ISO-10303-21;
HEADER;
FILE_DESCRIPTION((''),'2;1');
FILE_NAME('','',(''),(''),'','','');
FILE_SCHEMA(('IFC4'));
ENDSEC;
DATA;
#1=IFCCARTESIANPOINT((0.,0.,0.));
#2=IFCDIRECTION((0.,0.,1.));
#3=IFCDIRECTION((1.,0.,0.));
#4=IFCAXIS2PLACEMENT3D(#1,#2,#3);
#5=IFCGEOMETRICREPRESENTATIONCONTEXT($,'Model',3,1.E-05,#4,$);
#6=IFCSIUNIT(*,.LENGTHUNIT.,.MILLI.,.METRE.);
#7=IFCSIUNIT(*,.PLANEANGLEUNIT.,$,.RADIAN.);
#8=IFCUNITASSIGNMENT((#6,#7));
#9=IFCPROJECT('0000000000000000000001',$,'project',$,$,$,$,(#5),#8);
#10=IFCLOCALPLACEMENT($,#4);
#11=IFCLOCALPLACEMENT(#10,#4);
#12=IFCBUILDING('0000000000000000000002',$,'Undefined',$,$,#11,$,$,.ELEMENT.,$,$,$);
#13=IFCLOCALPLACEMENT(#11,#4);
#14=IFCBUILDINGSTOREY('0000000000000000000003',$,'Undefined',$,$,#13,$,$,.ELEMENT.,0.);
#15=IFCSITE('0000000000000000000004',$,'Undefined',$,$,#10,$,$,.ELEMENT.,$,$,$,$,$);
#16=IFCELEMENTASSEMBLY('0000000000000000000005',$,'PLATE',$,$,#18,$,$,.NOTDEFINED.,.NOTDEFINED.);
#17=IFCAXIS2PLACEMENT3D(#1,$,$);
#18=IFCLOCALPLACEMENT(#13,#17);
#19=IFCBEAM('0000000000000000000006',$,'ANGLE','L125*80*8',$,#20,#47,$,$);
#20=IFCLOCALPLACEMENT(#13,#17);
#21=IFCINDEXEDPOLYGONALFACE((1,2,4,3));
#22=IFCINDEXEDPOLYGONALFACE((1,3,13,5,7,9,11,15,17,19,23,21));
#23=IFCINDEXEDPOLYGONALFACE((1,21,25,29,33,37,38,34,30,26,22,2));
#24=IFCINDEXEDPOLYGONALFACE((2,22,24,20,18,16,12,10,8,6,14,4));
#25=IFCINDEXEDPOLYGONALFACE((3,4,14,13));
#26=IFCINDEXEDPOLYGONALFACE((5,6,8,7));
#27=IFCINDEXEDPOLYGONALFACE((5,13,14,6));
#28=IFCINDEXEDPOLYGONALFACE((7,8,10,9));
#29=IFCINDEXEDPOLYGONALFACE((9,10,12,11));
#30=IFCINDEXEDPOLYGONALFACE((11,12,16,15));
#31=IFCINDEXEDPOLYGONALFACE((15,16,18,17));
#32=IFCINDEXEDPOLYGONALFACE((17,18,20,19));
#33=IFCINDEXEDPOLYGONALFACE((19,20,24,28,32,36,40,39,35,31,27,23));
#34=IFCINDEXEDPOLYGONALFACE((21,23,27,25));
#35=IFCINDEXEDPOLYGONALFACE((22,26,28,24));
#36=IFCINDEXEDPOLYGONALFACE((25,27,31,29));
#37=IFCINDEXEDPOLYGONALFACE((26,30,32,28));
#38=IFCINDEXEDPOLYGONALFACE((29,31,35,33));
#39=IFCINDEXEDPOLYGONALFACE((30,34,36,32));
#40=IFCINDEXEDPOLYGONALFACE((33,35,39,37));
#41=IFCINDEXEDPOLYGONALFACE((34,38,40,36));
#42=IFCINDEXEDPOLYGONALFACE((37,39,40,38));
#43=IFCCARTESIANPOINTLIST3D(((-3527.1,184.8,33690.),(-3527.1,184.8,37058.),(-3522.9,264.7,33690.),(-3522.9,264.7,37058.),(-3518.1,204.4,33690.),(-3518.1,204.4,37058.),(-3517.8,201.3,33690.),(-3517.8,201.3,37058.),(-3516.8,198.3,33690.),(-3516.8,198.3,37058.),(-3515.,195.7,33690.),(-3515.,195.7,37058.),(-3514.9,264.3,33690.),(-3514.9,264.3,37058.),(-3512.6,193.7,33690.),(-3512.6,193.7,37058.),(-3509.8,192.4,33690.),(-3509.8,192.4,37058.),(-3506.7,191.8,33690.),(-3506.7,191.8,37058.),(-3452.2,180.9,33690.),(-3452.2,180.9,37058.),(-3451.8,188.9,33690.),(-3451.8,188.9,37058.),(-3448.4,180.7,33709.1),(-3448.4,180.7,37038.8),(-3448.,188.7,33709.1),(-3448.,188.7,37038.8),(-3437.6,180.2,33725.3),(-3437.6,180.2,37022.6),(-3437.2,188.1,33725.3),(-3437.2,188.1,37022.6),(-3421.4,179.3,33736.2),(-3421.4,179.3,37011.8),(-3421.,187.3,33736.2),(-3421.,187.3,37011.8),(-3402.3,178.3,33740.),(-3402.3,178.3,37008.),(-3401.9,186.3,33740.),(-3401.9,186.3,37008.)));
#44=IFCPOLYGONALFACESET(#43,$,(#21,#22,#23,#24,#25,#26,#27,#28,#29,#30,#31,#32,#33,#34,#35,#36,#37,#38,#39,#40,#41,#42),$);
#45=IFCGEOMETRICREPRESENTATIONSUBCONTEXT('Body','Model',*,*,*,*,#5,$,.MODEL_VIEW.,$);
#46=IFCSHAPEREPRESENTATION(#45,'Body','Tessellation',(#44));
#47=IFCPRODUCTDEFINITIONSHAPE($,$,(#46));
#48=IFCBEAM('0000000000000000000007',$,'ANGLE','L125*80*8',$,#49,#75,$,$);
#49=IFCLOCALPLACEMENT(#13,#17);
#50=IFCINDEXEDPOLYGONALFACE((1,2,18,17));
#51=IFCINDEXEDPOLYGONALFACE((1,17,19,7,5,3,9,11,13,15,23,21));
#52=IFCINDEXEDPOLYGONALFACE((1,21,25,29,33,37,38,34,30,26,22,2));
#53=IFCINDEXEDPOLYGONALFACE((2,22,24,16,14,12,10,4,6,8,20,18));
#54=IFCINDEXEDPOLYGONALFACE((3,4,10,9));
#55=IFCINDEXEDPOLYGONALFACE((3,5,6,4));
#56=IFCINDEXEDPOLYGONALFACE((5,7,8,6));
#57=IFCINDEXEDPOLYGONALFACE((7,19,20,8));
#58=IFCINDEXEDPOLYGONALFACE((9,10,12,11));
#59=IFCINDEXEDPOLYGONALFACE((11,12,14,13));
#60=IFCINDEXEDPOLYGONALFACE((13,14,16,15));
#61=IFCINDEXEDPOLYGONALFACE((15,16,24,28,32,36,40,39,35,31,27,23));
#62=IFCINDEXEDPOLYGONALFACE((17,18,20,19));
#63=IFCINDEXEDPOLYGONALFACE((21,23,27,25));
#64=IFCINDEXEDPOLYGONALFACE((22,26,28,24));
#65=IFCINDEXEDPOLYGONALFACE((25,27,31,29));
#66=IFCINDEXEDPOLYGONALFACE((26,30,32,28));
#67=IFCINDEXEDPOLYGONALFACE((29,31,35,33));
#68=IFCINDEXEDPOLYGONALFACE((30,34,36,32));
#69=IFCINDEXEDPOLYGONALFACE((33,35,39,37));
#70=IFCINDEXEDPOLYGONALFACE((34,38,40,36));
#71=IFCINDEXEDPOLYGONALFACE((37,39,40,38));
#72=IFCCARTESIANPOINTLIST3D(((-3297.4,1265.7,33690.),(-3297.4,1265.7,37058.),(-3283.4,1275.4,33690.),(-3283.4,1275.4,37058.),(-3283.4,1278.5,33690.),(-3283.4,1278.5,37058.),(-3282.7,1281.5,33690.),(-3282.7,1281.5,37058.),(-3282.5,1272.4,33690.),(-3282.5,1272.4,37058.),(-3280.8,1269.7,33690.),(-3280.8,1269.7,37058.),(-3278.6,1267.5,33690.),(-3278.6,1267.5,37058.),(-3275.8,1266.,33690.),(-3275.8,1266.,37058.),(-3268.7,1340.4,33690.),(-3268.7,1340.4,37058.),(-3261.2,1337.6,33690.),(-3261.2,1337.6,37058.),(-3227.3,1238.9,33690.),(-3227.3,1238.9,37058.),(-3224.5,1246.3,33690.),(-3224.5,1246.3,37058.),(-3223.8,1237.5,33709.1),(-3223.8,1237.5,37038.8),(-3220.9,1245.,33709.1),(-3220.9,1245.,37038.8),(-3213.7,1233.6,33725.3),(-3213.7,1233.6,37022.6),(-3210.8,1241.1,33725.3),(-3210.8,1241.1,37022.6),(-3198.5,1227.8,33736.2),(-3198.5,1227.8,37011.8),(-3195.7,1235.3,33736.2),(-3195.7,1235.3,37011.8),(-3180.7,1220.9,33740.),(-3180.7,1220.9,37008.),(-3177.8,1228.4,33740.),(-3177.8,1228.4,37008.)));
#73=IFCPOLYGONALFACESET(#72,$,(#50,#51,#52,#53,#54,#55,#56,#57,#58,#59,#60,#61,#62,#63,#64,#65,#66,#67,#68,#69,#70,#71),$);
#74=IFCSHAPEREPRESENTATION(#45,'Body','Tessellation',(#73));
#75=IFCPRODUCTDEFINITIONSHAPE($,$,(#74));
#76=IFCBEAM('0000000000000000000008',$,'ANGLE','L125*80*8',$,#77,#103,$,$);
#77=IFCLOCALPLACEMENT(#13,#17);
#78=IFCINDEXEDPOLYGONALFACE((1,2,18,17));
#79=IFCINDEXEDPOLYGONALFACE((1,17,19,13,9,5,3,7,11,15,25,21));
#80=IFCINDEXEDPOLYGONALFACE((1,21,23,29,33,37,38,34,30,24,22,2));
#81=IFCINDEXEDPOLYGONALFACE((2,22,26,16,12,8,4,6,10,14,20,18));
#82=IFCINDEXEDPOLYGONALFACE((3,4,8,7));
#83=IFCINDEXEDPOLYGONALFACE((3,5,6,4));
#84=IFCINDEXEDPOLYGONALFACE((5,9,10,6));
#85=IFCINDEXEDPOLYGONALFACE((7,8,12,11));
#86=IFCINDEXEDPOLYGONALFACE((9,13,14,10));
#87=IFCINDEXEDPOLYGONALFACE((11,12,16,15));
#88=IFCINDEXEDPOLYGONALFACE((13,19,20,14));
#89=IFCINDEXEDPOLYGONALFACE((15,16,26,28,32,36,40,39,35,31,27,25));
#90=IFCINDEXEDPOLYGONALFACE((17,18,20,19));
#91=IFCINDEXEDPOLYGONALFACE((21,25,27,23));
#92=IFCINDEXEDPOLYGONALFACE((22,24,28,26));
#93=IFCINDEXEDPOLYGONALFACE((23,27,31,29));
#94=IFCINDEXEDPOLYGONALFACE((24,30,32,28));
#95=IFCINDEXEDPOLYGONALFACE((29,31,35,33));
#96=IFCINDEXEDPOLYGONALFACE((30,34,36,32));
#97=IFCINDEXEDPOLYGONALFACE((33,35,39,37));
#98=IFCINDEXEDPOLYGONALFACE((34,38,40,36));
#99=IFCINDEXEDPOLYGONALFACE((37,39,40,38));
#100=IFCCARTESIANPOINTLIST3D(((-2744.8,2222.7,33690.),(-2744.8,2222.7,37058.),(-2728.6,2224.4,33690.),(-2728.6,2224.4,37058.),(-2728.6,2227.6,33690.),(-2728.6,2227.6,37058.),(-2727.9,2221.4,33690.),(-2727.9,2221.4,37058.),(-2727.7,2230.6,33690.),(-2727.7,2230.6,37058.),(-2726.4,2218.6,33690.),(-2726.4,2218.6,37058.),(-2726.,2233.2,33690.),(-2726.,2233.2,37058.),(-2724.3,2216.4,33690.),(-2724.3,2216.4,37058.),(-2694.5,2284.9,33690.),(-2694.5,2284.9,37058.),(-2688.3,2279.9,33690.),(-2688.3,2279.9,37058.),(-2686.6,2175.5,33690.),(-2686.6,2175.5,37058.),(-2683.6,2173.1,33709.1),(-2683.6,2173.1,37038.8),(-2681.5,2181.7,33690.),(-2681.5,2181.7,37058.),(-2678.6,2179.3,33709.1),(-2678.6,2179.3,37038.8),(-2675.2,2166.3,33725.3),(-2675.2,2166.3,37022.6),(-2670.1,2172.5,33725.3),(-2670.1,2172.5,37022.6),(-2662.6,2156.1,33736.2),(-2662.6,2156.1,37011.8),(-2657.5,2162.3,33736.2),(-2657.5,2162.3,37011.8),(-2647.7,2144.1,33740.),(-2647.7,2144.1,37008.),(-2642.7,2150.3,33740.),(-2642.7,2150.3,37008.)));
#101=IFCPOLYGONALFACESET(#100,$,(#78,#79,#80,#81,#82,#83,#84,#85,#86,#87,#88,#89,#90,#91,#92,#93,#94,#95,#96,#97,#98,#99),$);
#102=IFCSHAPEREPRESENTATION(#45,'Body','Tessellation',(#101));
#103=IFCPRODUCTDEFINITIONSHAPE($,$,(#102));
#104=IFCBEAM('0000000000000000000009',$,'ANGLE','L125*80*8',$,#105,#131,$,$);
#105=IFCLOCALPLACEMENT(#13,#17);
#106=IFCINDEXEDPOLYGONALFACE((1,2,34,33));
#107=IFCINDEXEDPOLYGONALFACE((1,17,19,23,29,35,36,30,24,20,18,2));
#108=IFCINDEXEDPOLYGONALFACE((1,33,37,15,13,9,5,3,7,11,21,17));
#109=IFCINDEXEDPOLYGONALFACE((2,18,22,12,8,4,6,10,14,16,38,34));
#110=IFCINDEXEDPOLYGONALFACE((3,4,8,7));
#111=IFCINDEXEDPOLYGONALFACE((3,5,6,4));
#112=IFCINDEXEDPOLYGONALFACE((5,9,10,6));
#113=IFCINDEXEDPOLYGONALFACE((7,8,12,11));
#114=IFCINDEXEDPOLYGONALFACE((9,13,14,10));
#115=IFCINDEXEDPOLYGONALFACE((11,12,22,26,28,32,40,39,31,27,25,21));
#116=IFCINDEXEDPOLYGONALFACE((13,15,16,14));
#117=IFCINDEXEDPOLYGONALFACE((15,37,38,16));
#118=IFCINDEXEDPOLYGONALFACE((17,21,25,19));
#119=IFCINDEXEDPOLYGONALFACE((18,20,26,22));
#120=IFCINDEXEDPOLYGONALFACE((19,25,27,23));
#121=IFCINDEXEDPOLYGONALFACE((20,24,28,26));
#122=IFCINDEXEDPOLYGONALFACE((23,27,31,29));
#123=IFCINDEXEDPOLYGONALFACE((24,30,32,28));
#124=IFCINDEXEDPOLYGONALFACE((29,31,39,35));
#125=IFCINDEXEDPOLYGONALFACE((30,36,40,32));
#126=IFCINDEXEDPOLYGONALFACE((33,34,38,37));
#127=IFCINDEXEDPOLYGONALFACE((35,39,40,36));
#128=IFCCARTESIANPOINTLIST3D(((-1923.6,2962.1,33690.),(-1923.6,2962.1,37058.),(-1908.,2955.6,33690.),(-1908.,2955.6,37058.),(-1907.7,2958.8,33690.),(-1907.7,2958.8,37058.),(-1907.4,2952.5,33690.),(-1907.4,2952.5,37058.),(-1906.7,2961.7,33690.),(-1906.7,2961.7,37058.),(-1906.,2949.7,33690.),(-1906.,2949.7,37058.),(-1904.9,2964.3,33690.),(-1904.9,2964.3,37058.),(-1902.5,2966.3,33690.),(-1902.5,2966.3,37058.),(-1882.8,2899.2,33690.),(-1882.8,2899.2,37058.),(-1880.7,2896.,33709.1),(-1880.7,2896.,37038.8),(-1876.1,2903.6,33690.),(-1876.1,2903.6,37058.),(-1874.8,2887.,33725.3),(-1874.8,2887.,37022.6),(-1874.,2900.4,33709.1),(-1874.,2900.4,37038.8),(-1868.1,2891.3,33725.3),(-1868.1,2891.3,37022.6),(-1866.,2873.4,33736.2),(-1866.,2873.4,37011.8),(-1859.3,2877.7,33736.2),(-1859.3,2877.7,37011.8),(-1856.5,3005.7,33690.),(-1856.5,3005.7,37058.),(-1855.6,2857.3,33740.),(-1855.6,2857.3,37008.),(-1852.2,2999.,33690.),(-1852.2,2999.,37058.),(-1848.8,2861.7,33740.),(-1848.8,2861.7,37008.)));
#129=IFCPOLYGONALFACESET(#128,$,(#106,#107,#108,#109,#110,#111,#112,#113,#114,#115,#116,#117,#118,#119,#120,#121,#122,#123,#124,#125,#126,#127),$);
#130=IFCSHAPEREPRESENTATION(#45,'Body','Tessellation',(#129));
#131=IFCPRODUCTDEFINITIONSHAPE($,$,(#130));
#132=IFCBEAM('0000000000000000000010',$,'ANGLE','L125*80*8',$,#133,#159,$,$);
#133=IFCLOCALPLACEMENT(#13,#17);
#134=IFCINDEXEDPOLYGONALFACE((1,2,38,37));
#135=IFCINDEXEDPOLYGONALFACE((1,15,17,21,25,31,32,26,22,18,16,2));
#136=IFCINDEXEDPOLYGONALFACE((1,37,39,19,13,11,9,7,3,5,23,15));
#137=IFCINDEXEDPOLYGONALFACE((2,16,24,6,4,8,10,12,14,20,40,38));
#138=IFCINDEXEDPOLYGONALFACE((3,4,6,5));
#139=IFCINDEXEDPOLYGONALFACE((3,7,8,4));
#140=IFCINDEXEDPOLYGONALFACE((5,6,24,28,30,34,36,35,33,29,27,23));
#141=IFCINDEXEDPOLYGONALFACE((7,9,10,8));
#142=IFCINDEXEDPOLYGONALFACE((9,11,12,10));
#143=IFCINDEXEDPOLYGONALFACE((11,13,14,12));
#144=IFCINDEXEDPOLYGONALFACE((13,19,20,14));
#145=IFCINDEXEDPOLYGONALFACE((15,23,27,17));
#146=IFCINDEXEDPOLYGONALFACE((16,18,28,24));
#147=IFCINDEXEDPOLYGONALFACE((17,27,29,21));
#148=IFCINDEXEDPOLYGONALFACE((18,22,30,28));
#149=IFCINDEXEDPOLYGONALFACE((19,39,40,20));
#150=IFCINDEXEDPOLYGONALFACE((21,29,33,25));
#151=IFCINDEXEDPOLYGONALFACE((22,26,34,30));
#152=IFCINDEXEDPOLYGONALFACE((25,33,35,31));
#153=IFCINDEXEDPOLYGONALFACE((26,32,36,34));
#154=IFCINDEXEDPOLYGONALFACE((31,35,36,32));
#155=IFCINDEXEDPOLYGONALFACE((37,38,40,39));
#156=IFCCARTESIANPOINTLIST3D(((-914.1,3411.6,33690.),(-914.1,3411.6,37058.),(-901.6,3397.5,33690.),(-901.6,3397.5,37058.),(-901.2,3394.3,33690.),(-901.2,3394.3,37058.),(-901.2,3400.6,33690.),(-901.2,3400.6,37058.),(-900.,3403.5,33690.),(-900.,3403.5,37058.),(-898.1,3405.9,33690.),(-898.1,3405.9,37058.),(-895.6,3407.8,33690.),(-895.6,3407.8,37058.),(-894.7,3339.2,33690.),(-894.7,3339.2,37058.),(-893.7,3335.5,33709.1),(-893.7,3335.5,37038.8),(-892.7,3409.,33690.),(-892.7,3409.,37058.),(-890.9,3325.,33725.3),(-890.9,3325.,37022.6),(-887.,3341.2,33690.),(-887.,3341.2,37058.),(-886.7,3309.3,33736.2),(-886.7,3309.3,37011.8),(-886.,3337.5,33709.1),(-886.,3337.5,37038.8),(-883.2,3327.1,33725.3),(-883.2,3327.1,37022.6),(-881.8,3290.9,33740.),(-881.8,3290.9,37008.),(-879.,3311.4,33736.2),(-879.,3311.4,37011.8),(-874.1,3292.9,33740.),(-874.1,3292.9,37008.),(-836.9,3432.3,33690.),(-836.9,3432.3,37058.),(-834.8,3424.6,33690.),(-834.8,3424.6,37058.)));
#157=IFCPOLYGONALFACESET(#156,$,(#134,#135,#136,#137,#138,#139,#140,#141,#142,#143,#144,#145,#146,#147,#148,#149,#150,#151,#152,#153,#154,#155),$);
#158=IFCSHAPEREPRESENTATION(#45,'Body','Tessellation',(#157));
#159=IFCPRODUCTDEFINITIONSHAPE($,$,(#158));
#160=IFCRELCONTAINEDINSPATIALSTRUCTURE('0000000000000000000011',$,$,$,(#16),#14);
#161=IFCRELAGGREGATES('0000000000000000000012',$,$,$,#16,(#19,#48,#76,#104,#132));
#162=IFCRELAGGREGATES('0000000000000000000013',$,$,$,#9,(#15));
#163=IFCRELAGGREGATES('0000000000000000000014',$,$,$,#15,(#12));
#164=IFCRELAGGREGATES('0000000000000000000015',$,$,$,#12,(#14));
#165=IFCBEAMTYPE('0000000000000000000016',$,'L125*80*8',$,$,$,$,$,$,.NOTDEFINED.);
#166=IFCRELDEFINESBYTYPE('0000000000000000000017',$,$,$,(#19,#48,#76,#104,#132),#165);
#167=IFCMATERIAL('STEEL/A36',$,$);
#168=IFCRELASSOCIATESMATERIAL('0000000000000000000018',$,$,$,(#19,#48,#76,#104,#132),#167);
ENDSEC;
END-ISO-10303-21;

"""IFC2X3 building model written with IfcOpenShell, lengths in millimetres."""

from ifc_helpers import new_model, si_unit, frame, origin_with_axes, origin_2d_with_axis, place, context, subcontext, project, spatial, polyline, l_section, outline, extrude, boolean, material, type_object, element, aggregate, save


model = new_model("IFC2X3")

# Units and contexts
model_context = context("Model", 3, precision=1e-05, world=origin_with_axes())
body_context = subcontext(model_context, "Body", "Model", "MODEL_VIEW")
ifc_project = project(units=[si_unit("LENGTHUNIT", "METRE", prefix="MILLI"), si_unit("PLANEANGLEUNIT", "RADIAN")], contexts=[model_context])

# Site, building, storey
site_placement = place(None, origin_with_axes())
site = spatial("IfcSite", under=ifc_project, at=site_placement, Name="Undefined", CompositionType="ELEMENT")
building_placement = place(site_placement, origin_with_axes())
building = spatial("IfcBuilding", under=site, at=building_placement, Name="Undefined", CompositionType="ELEMENT")
storey_placement = place(building_placement, origin_with_axes())
storey = spatial("IfcBuildingStorey", under=building, at=storey_placement, Name="Undefined", CompositionType="ELEMENT", Elevation=0.0)

# Element assembly, beams
assembly_1_placement = place(storey_placement, origin_with_axes())
assembly_1 = element("IfcElementAssembly", 1, at=assembly_1_placement, inside=storey, Name="PLATE", AssemblyPlace="NOTDEFINED", PredefinedType="NOTDEFINED")
ifc_material_1 = material(Name="STEEL/A36")
beam_type = type_object("IfcBeamType", Name="L125*80*8", PredefinedType="NOTDEFINED")
beam_1_placement = place(assembly_1_placement, frame((-3462.6, 221.5, 33690.0), z_axis=(0.99863, -0.052336, 0.0), x_axis=(0.0, 0.0, 1.0)))
beam_1 = element("IfcBeam", 2, at=beam_1_placement, type_object=beam_type, material=ifc_material_1, Name="ANGLE", Description="L125*80*8", context=body_context, shape_type="CSG", body=[
    boolean("DIFFERENCE", boolean("DIFFERENCE", extrude(l_section(Depth=125.0, Width=80.0, Thickness=8.0, FilletRadius=12.0, at=origin_2d_with_axis()), frame((3368.0, 0.0, 0.0), z_axis=(-1.0, 0.0, 0.0), x_axis=(0.0, -1.0, 0.0)), (0.0, 0.0, 1.0), 3368.0), extrude(outline(polyline([(0.0, 0.0), (50.0, 0.0), (50.0, 0.0), (46.2, 19.1), (35.4, 35.4), (19.1, 46.2), (0.0, 50.0), (0.0, 50.0), (0.0, 0.0)])), frame((0.0, -38.0, 62.5), z_axis=(0.0, 1.0, 0.0), x_axis=(1.0, 0.0, 0.0)), (0.0, 0.0, 1.0), 81.0)), extrude(outline(polyline([(0.0, 0.0), (50.0, 0.0), (50.0, 0.0), (46.2, 19.1), (35.4, 35.4), (19.1, 46.2), (0.0, 50.0), (0.0, 50.0), (0.0, 0.0)])), frame((3368.0, -38.0, 62.5), z_axis=(0.0, 1.0, 0.0), x_axis=(-0.000152, -0.000001, -1.0)), (0.0, 0.0, 1.0), 81.0)),
])
beam_2_placement = place(assembly_1_placement, frame((-3224.7, 1280.7, 33690.0), z_axis=(0.93358, -0.358368, 0.0), x_axis=(0.0, 0.0, 1.0)))
beam_2 = element("IfcBeam", 3, at=beam_2_placement, type_object=beam_type, material=ifc_material_1, Name="ANGLE", Description="L125*80*8", context=body_context, shape_type="CSG", body=[
    boolean("DIFFERENCE", boolean("DIFFERENCE", extrude(l_section(Depth=125.0, Width=80.0, Thickness=8.0, FilletRadius=12.0, at=origin_2d_with_axis()), frame((3368.0, 0.0, 0.0), z_axis=(-1.0, 0.0, 0.0), x_axis=(0.0, -1.0, 0.0)), (0.0, 0.0, 1.0), 3368.0), extrude(outline(polyline([(0.0, 0.0), (50.0, 0.0), (50.0, 0.0), (46.2, 19.1), (35.4, 35.4), (19.1, 46.2), (0.0, 50.0), (0.0, 50.0), (0.0, 0.0)])), frame((0.0, -38.0, 62.5), z_axis=(0.0, 1.0, 0.0), x_axis=(1.0, 0.0, 0.0)), (0.0, 0.0, 1.0), 81.0)), extrude(outline(polyline([(0.0, 0.0), (50.0, 0.0), (50.0, 0.0), (46.2, 19.1), (35.4, 35.4), (19.1, 46.2), (0.0, 50.0), (0.0, 50.0), (0.0, 0.0)])), frame((3368.0, -38.0, 62.5), z_axis=(0.0, 1.0, 0.0), x_axis=(-0.000152, -0.000001, -1.0)), (0.0, 0.0, 1.0), 81.0)),
])
beam_3_placement = place(assembly_1_placement, frame((-2671.1, 2214.5, 33690.0), z_axis=(0.777146, -0.62932, 0.0), x_axis=(0.0, 0.0, 1.0)))
beam_3 = element("IfcBeam", 4, at=beam_3_placement, type_object=beam_type, material=ifc_material_1, Name="ANGLE", Description="L125*80*8", context=body_context, shape_type="CSG", body=[
    boolean("DIFFERENCE", boolean("DIFFERENCE", extrude(l_section(Depth=125.0, Width=80.0, Thickness=8.0, FilletRadius=12.0, at=origin_2d_with_axis()), frame((3368.0, 0.0, 0.0), z_axis=(-1.0, 0.0, 0.0), x_axis=(0.0, -1.0, 0.0)), (0.0, 0.0, 1.0), 3368.0), extrude(outline(polyline([(0.0, 0.0), (50.0, 0.0), (50.0, 0.0), (46.2, 19.1), (35.4, 35.4), (19.1, 46.2), (0.0, 50.0), (0.0, 50.0), (0.0, 0.0)])), frame((0.0, -38.0, 62.5), z_axis=(0.0, 1.0, 0.0), x_axis=(1.0, 0.0, 0.0)), (0.0, 0.0, 1.0), 81.0)), extrude(outline(polyline([(0.0, 0.0), (50.0, 0.0), (50.0, 0.0), (46.2, 19.1), (35.4, 35.4), (19.1, 46.2), (0.0, 50.0), (0.0, 50.0), (0.0, 0.0)])), frame((3368.0, -38.0, 62.5), z_axis=(0.0, 1.0, 0.0), x_axis=(-0.000152, -0.000001, -1.0)), (0.0, 0.0, 1.0), 81.0)),
])
beam_4_placement = place(assembly_1_placement, frame((-1856.0, 2931.5, 33690.0), z_axis=(0.544639, -0.838671, 0.0), x_axis=(0.0, 0.0, 1.0)))
beam_4 = element("IfcBeam", 5, at=beam_4_placement, type_object=beam_type, material=ifc_material_1, Name="ANGLE", Description="L125*80*8", context=body_context, shape_type="CSG", body=[
    boolean("DIFFERENCE", boolean("DIFFERENCE", extrude(l_section(Depth=125.0, Width=80.0, Thickness=8.0, FilletRadius=12.0, at=origin_2d_with_axis()), frame((3368.0, 0.0, 0.0), z_axis=(-1.0, 0.0, 0.0), x_axis=(0.0, -1.0, 0.0)), (0.0, 0.0, 1.0), 3368.0), extrude(outline(polyline([(0.0, 0.0), (50.0, 0.0), (50.0, 0.0), (46.2, 19.1), (35.4, 35.4), (19.1, 46.2), (0.0, 50.0), (0.0, 50.0), (0.0, 0.0)])), frame((0.0, -38.0, 62.5), z_axis=(0.0, 1.0, 0.0), x_axis=(1.0, 0.0, 0.0)), (0.0, 0.0, 1.0), 81.0)), extrude(outline(polyline([(0.0, 0.0), (50.0, 0.0), (50.0, 0.0), (46.2, 19.1), (35.4, 35.4), (19.1, 46.2), (0.0, 50.0), (0.0, 50.0), (0.0, 0.0)])), frame((3368.0, -38.0, 62.5), z_axis=(0.0, 1.0, 0.0), x_axis=(-0.000152, -0.000001, -1.0)), (0.0, 0.0, 1.0), 81.0)),
])
beam_5_placement = place(assembly_1_placement, frame((-859.3, 3361.6, 33690.0), z_axis=(0.258819, -0.965926, 0.0), x_axis=(0.0, 0.0, 1.0)))
beam_5 = element("IfcBeam", 6, at=beam_5_placement, type_object=beam_type, material=ifc_material_1, Name="ANGLE", Description="L125*80*8", context=body_context, shape_type="CSG", body=[
    boolean("DIFFERENCE", boolean("DIFFERENCE", extrude(l_section(Depth=125.0, Width=80.0, Thickness=8.0, FilletRadius=12.0, at=origin_2d_with_axis()), frame((3368.0, 0.0, 0.0), z_axis=(-1.0, 0.0, 0.0), x_axis=(0.0, -1.0, 0.0)), (0.0, 0.0, 1.0), 3368.0), extrude(outline(polyline([(0.0, 0.0), (50.0, 0.0), (50.0, 0.0), (46.2, 19.1), (35.4, 35.4), (19.1, 46.2), (0.0, 50.0), (0.0, 50.0), (0.0, 0.0)])), frame((0.0, -38.0, 62.5), z_axis=(0.0, 1.0, 0.0), x_axis=(1.0, 0.0, 0.0)), (0.0, 0.0, 1.0), 81.0)), extrude(outline(polyline([(0.0, 0.0), (50.0, 0.0), (50.0, 0.0), (46.2, 19.1), (35.4, 35.4), (19.1, 46.2), (0.0, 50.0), (0.0, 50.0), (0.0, 0.0)])), frame((3368.0, -38.0, 62.5), z_axis=(0.0, 1.0, 0.0), x_axis=(-0.000152, -0.000001, -1.0)), (0.0, 0.0, 1.0), 81.0)),
])
aggregate(assembly_1, [beam_1, beam_2, beam_3, beam_4, beam_5])

save(model, "model.ifc")
